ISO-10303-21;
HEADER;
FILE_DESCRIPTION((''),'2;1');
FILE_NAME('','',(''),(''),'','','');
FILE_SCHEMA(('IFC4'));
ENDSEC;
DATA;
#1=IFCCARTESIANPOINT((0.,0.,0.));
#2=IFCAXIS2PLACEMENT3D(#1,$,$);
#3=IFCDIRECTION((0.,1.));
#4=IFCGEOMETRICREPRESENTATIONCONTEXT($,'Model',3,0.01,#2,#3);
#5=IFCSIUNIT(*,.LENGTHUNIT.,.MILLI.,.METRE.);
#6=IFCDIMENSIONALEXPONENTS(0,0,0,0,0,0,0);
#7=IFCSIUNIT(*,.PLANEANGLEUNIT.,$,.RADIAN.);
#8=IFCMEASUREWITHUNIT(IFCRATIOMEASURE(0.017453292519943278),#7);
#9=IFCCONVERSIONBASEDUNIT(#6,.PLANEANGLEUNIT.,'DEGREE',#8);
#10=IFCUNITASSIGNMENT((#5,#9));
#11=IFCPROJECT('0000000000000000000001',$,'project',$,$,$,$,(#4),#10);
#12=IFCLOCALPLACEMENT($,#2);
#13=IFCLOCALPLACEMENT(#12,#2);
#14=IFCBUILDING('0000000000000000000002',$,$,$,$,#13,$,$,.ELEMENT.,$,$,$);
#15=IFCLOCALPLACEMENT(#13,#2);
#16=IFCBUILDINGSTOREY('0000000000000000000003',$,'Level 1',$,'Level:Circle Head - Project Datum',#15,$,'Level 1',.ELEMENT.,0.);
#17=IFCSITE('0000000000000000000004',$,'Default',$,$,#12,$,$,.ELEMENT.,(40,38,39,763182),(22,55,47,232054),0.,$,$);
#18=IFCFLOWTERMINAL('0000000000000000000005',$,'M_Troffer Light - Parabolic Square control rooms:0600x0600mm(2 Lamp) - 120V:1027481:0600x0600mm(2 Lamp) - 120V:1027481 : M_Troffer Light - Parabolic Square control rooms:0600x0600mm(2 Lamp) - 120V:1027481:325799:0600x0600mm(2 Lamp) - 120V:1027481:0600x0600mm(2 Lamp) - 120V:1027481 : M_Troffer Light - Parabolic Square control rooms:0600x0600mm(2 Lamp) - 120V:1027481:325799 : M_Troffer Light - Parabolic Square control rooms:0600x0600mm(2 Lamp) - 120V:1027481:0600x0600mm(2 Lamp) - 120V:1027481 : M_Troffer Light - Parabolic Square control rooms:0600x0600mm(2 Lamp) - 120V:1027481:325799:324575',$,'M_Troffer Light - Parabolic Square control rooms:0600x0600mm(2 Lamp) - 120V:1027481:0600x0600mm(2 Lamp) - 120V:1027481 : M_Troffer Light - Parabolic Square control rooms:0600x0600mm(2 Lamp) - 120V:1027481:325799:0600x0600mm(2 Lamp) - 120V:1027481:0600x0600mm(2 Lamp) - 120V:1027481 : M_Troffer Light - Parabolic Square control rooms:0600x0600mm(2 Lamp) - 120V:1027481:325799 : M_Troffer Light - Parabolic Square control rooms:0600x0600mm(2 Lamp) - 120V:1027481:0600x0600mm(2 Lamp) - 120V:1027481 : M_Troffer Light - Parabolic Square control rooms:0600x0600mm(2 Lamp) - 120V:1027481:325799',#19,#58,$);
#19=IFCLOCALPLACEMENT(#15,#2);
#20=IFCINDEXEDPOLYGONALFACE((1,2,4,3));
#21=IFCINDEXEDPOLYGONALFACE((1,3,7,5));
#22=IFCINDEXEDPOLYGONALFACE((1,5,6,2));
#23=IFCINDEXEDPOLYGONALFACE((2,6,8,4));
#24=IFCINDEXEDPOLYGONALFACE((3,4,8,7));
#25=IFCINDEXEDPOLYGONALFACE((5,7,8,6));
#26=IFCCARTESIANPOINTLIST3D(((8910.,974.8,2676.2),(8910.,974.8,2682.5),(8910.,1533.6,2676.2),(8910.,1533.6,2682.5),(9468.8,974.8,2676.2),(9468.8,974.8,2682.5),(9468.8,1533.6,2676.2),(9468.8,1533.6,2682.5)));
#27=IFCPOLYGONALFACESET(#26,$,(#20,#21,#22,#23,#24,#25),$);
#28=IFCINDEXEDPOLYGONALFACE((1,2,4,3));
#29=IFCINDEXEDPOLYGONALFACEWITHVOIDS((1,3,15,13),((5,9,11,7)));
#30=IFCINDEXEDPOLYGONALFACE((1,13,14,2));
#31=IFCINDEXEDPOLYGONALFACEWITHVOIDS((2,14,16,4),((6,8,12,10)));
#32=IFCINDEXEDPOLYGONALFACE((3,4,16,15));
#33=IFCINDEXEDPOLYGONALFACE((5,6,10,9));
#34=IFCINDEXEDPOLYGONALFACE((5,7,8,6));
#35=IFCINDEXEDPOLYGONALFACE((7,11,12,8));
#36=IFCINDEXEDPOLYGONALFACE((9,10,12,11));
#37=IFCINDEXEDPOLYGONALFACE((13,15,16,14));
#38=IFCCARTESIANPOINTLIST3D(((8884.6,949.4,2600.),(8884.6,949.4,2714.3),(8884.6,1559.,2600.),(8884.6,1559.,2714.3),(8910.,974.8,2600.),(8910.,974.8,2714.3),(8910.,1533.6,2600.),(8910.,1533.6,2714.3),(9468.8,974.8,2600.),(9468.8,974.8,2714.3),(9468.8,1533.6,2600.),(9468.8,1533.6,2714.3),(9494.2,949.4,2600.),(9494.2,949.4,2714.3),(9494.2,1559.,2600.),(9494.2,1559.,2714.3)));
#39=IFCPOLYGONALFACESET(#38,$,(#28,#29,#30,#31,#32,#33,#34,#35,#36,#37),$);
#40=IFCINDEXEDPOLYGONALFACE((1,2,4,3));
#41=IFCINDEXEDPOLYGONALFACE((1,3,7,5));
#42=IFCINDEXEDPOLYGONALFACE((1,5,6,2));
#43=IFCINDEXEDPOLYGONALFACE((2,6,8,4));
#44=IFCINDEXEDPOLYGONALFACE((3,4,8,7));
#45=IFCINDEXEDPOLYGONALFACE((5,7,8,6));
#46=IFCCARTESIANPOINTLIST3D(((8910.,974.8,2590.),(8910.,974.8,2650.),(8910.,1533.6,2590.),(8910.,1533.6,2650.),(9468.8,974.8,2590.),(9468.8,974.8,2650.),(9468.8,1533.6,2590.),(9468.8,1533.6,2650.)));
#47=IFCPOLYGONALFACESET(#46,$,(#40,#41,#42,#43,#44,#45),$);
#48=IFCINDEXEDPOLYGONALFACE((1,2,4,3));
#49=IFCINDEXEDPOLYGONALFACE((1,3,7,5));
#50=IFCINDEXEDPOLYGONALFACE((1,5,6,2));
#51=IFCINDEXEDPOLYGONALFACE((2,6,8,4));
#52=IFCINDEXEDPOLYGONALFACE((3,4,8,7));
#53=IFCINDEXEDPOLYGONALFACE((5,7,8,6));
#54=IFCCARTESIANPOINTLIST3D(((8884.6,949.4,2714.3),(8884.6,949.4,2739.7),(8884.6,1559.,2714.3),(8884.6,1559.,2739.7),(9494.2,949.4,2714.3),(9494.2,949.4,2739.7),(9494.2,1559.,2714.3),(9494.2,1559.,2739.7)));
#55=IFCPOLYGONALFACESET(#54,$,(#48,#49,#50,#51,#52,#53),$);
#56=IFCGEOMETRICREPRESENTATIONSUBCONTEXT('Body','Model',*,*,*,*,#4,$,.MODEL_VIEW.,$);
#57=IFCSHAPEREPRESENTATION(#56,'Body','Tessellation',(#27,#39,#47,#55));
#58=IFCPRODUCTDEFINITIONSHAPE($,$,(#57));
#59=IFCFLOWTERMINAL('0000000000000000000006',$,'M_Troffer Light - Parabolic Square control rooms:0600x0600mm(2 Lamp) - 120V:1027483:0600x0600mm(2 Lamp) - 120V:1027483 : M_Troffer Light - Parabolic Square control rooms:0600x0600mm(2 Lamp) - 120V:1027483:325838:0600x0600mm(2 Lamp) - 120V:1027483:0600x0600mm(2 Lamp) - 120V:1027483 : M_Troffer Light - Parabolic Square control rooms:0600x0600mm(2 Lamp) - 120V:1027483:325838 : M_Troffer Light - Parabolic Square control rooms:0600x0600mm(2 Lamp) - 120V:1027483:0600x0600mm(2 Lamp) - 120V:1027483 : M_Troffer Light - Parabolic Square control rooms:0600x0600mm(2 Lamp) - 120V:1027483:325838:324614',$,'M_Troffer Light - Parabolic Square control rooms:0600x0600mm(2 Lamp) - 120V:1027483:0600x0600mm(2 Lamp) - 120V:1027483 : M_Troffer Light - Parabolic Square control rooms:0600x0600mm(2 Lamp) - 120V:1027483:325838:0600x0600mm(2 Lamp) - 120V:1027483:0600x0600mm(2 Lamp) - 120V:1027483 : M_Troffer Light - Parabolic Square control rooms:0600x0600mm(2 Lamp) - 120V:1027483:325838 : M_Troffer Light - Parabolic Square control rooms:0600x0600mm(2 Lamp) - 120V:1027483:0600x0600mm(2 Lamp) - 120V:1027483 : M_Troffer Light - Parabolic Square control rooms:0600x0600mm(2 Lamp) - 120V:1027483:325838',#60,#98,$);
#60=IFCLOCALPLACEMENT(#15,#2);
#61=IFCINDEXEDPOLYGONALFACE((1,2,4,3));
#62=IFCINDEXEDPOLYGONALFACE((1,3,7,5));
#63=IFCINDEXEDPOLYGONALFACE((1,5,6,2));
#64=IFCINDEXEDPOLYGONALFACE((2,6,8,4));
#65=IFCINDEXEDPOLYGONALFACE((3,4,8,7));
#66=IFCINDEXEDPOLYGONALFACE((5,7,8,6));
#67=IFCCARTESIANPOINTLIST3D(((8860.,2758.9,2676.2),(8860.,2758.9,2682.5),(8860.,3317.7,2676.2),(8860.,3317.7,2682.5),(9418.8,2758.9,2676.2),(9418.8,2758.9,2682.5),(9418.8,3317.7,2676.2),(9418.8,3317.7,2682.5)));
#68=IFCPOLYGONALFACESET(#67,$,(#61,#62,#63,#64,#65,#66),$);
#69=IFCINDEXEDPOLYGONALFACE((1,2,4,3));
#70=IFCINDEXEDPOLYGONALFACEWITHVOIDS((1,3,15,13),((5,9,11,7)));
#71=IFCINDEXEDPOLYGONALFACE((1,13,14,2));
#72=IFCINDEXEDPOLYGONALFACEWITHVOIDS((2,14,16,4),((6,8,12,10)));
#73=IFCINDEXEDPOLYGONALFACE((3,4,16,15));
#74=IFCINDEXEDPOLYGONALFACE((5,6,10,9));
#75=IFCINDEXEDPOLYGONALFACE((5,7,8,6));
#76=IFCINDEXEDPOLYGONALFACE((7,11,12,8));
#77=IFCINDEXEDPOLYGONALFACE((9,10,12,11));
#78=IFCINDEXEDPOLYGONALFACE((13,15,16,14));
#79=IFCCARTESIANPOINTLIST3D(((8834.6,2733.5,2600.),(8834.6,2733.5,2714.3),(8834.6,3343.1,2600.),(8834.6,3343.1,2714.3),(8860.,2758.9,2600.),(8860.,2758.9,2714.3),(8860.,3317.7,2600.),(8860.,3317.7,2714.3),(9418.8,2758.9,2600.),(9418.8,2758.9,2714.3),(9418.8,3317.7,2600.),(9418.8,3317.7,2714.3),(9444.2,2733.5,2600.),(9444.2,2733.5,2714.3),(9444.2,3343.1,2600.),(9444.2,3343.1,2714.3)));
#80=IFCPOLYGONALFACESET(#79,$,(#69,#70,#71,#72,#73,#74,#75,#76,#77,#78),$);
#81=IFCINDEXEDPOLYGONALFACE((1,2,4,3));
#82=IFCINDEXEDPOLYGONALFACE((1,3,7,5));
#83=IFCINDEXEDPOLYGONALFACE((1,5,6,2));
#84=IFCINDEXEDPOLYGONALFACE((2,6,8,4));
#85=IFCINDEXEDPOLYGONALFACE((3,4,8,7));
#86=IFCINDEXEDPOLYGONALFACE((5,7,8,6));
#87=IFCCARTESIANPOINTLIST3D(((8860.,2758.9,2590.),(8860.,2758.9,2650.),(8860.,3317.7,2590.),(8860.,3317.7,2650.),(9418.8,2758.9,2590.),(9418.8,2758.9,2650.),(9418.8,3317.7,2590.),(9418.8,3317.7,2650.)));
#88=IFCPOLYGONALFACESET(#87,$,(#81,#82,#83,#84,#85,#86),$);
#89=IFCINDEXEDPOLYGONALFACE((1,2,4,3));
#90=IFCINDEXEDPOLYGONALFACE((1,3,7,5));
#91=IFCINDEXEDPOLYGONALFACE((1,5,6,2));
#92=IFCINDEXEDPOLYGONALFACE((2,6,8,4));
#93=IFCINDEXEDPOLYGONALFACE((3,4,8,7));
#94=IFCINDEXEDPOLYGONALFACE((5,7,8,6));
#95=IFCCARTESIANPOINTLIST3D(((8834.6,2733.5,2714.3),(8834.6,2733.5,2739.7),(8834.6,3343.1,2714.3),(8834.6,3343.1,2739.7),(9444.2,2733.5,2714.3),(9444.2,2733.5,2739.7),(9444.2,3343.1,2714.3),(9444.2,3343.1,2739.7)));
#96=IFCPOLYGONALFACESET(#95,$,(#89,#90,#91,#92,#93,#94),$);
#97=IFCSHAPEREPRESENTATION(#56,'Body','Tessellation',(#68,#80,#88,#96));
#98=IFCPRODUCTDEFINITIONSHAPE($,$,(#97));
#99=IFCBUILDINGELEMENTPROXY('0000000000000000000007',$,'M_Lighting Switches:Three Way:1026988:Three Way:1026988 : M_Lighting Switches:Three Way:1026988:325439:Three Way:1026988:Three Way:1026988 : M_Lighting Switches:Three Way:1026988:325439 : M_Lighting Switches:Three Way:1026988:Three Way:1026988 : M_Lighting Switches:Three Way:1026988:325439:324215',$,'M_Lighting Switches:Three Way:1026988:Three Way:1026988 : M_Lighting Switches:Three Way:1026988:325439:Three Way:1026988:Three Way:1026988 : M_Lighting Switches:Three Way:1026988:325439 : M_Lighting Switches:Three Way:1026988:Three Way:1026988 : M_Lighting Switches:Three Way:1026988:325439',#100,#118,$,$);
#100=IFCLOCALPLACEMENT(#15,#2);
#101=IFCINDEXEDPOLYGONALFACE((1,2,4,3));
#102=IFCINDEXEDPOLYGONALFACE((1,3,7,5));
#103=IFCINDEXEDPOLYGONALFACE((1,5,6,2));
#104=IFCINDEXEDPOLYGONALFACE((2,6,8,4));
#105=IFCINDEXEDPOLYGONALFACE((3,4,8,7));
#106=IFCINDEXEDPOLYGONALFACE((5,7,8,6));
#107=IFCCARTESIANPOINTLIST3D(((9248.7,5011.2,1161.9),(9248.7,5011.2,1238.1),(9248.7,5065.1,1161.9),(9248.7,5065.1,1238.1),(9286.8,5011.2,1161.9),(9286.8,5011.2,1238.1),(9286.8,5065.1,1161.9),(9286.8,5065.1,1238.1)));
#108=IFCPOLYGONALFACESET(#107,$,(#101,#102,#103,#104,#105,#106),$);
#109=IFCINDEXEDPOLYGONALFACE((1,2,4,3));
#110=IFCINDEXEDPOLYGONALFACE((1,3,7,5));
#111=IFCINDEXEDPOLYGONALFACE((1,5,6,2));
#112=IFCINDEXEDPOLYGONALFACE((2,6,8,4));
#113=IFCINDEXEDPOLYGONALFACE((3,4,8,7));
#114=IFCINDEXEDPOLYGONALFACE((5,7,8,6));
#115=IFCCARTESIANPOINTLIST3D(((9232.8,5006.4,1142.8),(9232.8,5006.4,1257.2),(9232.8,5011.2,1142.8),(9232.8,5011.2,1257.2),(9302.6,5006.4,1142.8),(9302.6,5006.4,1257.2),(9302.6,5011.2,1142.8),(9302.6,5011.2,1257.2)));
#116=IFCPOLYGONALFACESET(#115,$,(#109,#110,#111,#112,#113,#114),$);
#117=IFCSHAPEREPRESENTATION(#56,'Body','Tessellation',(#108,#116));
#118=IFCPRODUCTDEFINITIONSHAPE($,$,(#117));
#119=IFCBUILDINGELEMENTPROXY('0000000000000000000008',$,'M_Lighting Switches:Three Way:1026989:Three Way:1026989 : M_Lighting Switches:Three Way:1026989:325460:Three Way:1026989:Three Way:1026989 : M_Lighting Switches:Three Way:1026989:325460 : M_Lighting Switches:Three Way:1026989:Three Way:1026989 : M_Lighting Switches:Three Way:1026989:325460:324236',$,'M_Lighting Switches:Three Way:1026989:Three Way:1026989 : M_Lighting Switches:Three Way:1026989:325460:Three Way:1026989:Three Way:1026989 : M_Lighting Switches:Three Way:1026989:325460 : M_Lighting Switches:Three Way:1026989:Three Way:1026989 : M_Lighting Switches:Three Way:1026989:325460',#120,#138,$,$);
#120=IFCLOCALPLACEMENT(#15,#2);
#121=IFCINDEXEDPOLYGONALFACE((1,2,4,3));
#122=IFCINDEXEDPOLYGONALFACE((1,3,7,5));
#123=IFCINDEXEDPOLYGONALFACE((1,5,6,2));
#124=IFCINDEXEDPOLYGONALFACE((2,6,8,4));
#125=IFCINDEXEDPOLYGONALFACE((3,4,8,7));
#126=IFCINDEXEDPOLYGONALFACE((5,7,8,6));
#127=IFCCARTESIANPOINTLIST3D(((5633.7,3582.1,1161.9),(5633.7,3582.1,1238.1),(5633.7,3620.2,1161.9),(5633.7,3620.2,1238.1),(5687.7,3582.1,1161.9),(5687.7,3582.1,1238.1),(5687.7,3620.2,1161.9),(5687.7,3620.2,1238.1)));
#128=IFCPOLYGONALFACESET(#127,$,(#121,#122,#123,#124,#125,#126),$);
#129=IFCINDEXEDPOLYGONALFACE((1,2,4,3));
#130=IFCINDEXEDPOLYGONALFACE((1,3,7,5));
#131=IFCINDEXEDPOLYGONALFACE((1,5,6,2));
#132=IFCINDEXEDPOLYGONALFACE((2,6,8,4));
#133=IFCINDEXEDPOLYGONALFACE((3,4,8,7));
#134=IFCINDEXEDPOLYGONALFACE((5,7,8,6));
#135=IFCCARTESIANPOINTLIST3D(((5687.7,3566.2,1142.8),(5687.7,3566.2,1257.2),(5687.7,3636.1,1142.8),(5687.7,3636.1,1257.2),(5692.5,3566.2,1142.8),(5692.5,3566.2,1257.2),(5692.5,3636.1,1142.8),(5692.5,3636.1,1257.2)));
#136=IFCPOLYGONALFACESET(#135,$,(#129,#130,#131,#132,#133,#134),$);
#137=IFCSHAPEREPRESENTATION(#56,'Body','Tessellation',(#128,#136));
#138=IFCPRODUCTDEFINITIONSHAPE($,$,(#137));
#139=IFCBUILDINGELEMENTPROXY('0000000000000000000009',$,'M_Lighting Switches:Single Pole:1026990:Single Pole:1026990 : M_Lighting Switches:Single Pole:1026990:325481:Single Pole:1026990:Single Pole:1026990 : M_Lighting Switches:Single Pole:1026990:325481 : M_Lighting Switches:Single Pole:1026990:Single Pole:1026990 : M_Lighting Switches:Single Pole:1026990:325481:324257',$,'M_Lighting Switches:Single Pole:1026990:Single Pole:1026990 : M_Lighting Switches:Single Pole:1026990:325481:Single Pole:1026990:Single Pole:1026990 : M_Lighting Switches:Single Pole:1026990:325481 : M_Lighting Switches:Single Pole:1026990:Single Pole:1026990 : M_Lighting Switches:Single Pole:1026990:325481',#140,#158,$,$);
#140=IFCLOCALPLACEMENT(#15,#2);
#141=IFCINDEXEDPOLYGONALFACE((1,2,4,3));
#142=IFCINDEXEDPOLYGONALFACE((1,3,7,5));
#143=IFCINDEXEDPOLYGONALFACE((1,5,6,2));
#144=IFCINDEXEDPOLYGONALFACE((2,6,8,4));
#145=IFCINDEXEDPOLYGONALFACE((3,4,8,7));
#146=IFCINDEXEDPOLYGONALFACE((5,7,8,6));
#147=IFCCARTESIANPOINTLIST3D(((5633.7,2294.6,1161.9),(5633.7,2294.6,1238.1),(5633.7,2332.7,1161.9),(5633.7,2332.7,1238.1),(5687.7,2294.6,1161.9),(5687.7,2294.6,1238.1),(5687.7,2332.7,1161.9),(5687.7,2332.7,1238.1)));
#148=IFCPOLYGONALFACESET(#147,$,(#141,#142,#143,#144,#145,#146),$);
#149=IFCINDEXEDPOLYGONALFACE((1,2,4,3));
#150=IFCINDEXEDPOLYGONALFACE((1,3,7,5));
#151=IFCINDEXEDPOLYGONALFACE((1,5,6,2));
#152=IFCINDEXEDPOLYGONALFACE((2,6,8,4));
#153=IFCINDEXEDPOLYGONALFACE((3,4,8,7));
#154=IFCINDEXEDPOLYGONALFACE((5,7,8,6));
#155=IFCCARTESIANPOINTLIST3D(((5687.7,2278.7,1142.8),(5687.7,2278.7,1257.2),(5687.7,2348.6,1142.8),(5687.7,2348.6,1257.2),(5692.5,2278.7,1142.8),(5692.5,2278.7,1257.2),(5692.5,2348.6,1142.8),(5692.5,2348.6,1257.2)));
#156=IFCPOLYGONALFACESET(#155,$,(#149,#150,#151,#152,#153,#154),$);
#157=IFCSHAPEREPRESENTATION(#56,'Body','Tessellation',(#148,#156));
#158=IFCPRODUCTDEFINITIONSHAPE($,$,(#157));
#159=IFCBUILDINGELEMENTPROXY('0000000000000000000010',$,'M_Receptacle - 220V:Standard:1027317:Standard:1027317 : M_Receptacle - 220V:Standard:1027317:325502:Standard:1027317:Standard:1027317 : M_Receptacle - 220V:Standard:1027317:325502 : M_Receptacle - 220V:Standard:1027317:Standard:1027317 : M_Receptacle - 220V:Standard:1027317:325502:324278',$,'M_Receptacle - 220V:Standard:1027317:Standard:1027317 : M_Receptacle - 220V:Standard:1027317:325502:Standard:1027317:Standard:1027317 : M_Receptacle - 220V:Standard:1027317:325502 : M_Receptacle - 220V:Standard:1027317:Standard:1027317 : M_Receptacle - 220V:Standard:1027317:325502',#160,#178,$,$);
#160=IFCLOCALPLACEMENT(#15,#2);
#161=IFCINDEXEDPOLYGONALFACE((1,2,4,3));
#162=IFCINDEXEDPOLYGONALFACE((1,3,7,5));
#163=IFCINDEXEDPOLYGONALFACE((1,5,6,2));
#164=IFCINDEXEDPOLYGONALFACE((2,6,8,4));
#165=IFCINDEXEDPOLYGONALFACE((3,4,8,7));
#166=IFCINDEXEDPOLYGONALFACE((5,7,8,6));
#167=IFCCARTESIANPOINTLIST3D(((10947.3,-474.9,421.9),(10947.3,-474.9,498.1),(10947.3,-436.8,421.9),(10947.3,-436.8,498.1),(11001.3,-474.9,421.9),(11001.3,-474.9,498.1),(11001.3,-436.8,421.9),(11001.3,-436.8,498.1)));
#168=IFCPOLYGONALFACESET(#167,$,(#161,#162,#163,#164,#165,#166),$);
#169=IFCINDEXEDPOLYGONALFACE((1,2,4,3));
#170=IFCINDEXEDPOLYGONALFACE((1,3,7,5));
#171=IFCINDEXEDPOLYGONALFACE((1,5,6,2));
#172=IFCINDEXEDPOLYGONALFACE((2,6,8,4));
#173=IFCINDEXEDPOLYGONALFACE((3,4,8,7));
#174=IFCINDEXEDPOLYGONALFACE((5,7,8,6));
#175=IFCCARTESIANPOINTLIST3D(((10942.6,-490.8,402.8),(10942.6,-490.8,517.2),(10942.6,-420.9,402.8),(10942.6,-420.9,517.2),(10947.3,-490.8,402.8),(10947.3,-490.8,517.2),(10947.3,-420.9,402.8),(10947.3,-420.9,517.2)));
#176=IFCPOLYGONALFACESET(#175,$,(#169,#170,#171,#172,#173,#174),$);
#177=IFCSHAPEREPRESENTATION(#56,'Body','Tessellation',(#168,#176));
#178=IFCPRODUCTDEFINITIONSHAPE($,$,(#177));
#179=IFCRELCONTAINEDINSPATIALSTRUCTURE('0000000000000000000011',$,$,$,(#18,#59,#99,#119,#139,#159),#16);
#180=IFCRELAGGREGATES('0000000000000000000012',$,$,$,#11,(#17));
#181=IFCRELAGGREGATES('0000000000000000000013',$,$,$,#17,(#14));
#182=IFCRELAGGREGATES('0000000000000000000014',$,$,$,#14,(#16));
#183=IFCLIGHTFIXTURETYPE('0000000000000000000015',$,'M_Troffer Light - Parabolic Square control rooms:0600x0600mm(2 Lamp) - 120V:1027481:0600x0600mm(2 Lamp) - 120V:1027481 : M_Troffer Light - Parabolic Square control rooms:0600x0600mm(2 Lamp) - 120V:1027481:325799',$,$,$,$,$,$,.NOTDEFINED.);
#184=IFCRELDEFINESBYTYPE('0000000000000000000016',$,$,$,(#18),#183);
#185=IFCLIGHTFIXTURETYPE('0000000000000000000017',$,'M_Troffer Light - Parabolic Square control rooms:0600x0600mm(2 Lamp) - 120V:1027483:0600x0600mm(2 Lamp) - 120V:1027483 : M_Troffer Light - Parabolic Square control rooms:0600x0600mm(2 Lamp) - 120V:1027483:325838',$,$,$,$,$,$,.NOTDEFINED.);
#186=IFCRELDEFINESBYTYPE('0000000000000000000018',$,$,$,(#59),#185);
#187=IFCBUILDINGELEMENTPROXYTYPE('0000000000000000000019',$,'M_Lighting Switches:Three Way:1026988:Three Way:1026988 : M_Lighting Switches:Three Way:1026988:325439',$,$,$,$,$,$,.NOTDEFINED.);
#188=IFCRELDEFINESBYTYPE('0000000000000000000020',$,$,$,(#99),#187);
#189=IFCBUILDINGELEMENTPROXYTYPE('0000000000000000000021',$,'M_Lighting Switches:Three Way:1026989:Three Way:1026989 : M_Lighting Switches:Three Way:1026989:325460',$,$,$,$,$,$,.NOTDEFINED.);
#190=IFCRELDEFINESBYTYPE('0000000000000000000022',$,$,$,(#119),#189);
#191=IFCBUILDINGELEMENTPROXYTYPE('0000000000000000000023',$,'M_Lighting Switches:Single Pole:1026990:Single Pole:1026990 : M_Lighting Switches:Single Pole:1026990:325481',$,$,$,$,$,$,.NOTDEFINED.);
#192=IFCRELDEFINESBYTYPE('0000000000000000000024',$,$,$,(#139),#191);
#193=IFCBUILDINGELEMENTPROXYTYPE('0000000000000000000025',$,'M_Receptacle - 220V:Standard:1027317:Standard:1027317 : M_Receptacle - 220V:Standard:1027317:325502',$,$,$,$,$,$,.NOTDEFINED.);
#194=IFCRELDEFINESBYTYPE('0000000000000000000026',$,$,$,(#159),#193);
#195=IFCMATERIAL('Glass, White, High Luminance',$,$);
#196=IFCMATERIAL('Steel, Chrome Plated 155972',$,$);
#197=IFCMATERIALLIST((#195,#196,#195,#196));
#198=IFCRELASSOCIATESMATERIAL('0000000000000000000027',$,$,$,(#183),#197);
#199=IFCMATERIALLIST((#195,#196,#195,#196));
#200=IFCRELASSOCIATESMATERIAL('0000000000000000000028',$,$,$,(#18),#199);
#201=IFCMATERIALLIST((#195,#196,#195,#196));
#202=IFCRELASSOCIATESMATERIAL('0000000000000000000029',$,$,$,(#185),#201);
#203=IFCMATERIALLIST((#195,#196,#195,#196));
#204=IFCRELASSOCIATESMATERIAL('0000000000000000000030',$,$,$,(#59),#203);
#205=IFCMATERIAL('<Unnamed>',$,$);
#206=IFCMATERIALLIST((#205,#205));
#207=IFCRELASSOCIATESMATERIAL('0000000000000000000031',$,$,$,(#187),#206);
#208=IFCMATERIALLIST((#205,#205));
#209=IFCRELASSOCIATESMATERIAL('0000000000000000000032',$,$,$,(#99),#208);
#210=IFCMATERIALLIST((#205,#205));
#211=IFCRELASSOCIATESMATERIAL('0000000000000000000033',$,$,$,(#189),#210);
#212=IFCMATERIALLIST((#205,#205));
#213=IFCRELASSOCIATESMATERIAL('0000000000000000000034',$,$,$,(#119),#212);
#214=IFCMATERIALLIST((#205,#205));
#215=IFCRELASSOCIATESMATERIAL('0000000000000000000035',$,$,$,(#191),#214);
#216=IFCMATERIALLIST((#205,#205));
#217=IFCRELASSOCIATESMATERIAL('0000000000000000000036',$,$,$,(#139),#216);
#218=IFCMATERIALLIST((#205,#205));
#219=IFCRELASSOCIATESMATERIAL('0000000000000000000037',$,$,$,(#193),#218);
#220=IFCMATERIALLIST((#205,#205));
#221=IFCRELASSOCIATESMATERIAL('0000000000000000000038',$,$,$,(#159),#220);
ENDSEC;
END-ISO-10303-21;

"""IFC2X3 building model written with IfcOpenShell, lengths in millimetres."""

from ifc_helpers import new_model, entity, si_unit, converted_unit, direction, frame, frame_2d, origin, origin_2d_with_axis, place, context, subcontext, project, spatial, polyline, rectangle, outline, extrude, source, transform, mapped, material, material_list, type_object, type_shapes, element, save


model = new_model("IFC2X3")

# Units and contexts
model_context = context("Model", 3, precision=0.01, world=origin(), true_north=direction((0.0, 1.0)))
body_context = subcontext(model_context, "Body", "Model", "MODEL_VIEW")
ifc_project = project(units=[si_unit("LENGTHUNIT", "METRE", prefix="MILLI"), converted_unit("PLANEANGLEUNIT", "DEGREE", entity("IfcRatioMeasure", 0.017453292519943278), si_unit("PLANEANGLEUNIT", "RADIAN"), dimensions=[0, 0, 0, 0, 0, 0, 0])], contexts=[model_context])

# Site, building, storey
site_placement = place(None, origin())
site = spatial("IfcSite", under=ifc_project, at=site_placement, Name="Default", CompositionType="ELEMENT", RefLatitude=(40, 38, 39, 763182), RefLongitude=(22, 55, 47, 232054), RefElevation=0.0)
building_placement = place(site_placement, origin())
building = spatial("IfcBuilding", under=site, at=building_placement, CompositionType="ELEMENT")
storey_placement = place(building_placement, origin())
storey = spatial("IfcBuildingStorey", under=building, at=storey_placement, Name="Level 1", ObjectType="Level:Circle Head - Project Datum", LongName="Level 1", CompositionType="ELEMENT", Elevation=0.0)

# Flow terminals
ifc_material_1 = material(Name="Glass, White, High Luminance")
ifc_material_2 = material(Name="Steel, Chrome Plated 155972")
ifc_material_list_1 = material_list([ifc_material_1, ifc_material_2, ifc_material_1, ifc_material_2])
ifc_material_list_2 = material_list([ifc_material_1, ifc_material_2, ifc_material_1, ifc_material_2])
light_fixture_type_1 = type_object("IfcLightFixtureType", Name="M_Troffer Light - Parabolic Square control rooms:0600x0600mm(2 Lamp) - 120V:1027481:0600x0600mm(2 Lamp) - 120V:1027481 : M_Troffer Light - Parabolic Square control rooms:0600x0600mm(2 Lamp) - 120V:1027481:325799", PredefinedType="NOTDEFINED", material=ifc_material_list_2)
shared_shape_1 = source(origin(), body_context, "Body", "SweptSolid", [
    extrude(rectangle(XDim=558.8, YDim=558.8, at=origin_2d_with_axis()), frame((9189.4, 1254.2, 2676.2), z_axis=(0.0, 0.0, 1.0), x_axis=(0.0, 1.0, 0.0)), (0.0, 0.0, 1.0), 6.4),
    extrude(outline(polyline([(-304.8, -304.8), (304.8, -304.8), (304.8, 304.8), (-304.8, 304.8), (-304.8, -304.8)]), holes=[polyline([(279.4, 279.4), (279.4, -279.4), (-279.4, -279.4), (-279.4, 279.4), (279.4, 279.4)])]), frame((9189.4, 1254.2, 2600.0), z_axis=(0.0, 0.0, 1.0), x_axis=(0.0, -1.0, 0.0)), (0.0, 0.0, 1.0), 114.3),
    extrude(rectangle(XDim=558.8, YDim=558.8, at=frame_2d((0.0, 0.0), x_axis=(1.0, 0.0))), frame((9189.4, 1254.2, 2590.0), z_axis=(0.0, 0.0, 1.0), x_axis=(0.0, 1.0, 0.0)), (0.0, 0.0, 1.0), 60.0),
    extrude(rectangle(XDim=609.6, YDim=609.6, at=frame_2d((0.0, 0.0), x_axis=(1.0, 0.0))), frame((9189.4, 1254.2, 2714.3), z_axis=(0.0, 0.0, 1.0), x_axis=(0.0, 1.0, 0.0)), (0.0, 0.0, 1.0), 25.4),
])
type_shapes(light_fixture_type_1, [shared_shape_1])
flow_terminal_1_placement = place(storey_placement, origin())
element("IfcFlowTerminal", 1, at=flow_terminal_1_placement, inside=storey, type_object=light_fixture_type_1, material=ifc_material_list_1, Name="M_Troffer Light - Parabolic Square control rooms:0600x0600mm(2 Lamp) - 120V:1027481:0600x0600mm(2 Lamp) - 120V:1027481 : M_Troffer Light - Parabolic Square control rooms:0600x0600mm(2 Lamp) - 120V:1027481:325799:0600x0600mm(2 Lamp) - 120V:1027481:0600x0600mm(2 Lamp) - 120V:1027481 : M_Troffer Light - Parabolic Square control rooms:0600x0600mm(2 Lamp) - 120V:1027481:325799 : M_Troffer Light - Parabolic Square control rooms:0600x0600mm(2 Lamp) - 120V:1027481:0600x0600mm(2 Lamp) - 120V:1027481 : M_Troffer Light - Parabolic Square control rooms:0600x0600mm(2 Lamp) - 120V:1027481:325799:324575", ObjectType="M_Troffer Light - Parabolic Square control rooms:0600x0600mm(2 Lamp) - 120V:1027481:0600x0600mm(2 Lamp) - 120V:1027481 : M_Troffer Light - Parabolic Square control rooms:0600x0600mm(2 Lamp) - 120V:1027481:325799:0600x0600mm(2 Lamp) - 120V:1027481:0600x0600mm(2 Lamp) - 120V:1027481 : M_Troffer Light - Parabolic Square control rooms:0600x0600mm(2 Lamp) - 120V:1027481:325799 : M_Troffer Light - Parabolic Square control rooms:0600x0600mm(2 Lamp) - 120V:1027481:0600x0600mm(2 Lamp) - 120V:1027481 : M_Troffer Light - Parabolic Square control rooms:0600x0600mm(2 Lamp) - 120V:1027481:325799", context=body_context, shape_type="MappedRepresentation", body=[
    mapped(shared_shape_1, transform((0.0, 0.0, 0.0), scale=1.0)),
])
ifc_material_list_3 = material_list([ifc_material_1, ifc_material_2, ifc_material_1, ifc_material_2])
ifc_material_list_4 = material_list([ifc_material_1, ifc_material_2, ifc_material_1, ifc_material_2])
light_fixture_type_2 = type_object("IfcLightFixtureType", Name="M_Troffer Light - Parabolic Square control rooms:0600x0600mm(2 Lamp) - 120V:1027483:0600x0600mm(2 Lamp) - 120V:1027483 : M_Troffer Light - Parabolic Square control rooms:0600x0600mm(2 Lamp) - 120V:1027483:325838", PredefinedType="NOTDEFINED", material=ifc_material_list_4)
shared_shape_2 = source(origin(), body_context, "Body", "SweptSolid", [
    extrude(rectangle(XDim=558.8, YDim=558.8, at=frame_2d((0.0, 0.0), x_axis=(1.0, 0.0))), frame((9139.4, 3038.3, 2676.2), z_axis=(0.0, 0.0, 1.0), x_axis=(0.0, 1.0, 0.0)), (0.0, 0.0, 1.0), 6.4),
    extrude(outline(polyline([(-304.8, -304.8), (304.8, -304.8), (304.8, 304.8), (-304.8, 304.8), (-304.8, -304.8)]), holes=[polyline([(279.4, 279.4), (279.4, -279.4), (-279.4, -279.4), (-279.4, 279.4), (279.4, 279.4)])]), frame((9139.4, 3038.3, 2600.0), z_axis=(0.0, 0.0, 1.0), x_axis=(0.0, -1.0, 0.0)), (0.0, 0.0, 1.0), 114.3),
    extrude(rectangle(XDim=558.8, YDim=558.8, at=frame_2d((0.0, 0.0), x_axis=(1.0, 0.0))), frame((9139.4, 3038.3, 2590.0), z_axis=(0.0, 0.0, 1.0), x_axis=(0.0, 1.0, 0.0)), (0.0, 0.0, 1.0), 60.0),
    extrude(rectangle(XDim=609.6, YDim=609.6, at=frame_2d((0.0, 0.0), x_axis=(1.0, 0.0))), frame((9139.4, 3038.3, 2714.3), z_axis=(0.0, 0.0, 1.0), x_axis=(0.0, 1.0, 0.0)), (0.0, 0.0, 1.0), 25.4),
])
type_shapes(light_fixture_type_2, [shared_shape_2])
flow_terminal_2_placement = place(storey_placement, origin())
element("IfcFlowTerminal", 2, at=flow_terminal_2_placement, inside=storey, type_object=light_fixture_type_2, material=ifc_material_list_3, Name="M_Troffer Light - Parabolic Square control rooms:0600x0600mm(2 Lamp) - 120V:1027483:0600x0600mm(2 Lamp) - 120V:1027483 : M_Troffer Light - Parabolic Square control rooms:0600x0600mm(2 Lamp) - 120V:1027483:325838:0600x0600mm(2 Lamp) - 120V:1027483:0600x0600mm(2 Lamp) - 120V:1027483 : M_Troffer Light - Parabolic Square control rooms:0600x0600mm(2 Lamp) - 120V:1027483:325838 : M_Troffer Light - Parabolic Square control rooms:0600x0600mm(2 Lamp) - 120V:1027483:0600x0600mm(2 Lamp) - 120V:1027483 : M_Troffer Light - Parabolic Square control rooms:0600x0600mm(2 Lamp) - 120V:1027483:325838:324614", ObjectType="M_Troffer Light - Parabolic Square control rooms:0600x0600mm(2 Lamp) - 120V:1027483:0600x0600mm(2 Lamp) - 120V:1027483 : M_Troffer Light - Parabolic Square control rooms:0600x0600mm(2 Lamp) - 120V:1027483:325838:0600x0600mm(2 Lamp) - 120V:1027483:0600x0600mm(2 Lamp) - 120V:1027483 : M_Troffer Light - Parabolic Square control rooms:0600x0600mm(2 Lamp) - 120V:1027483:325838 : M_Troffer Light - Parabolic Square control rooms:0600x0600mm(2 Lamp) - 120V:1027483:0600x0600mm(2 Lamp) - 120V:1027483 : M_Troffer Light - Parabolic Square control rooms:0600x0600mm(2 Lamp) - 120V:1027483:325838", context=body_context, shape_type="MappedRepresentation", body=[
    mapped(shared_shape_2, transform((0.0, 0.0, 0.0), scale=1.0)),
])

# Building element proxies
ifc_material_3 = material(Name="<Unnamed>")
ifc_material_list_5 = material_list([ifc_material_3, ifc_material_3])
ifc_material_list_6 = material_list([ifc_material_3, ifc_material_3])
building_element_proxy_type_1 = type_object("IfcBuildingElementProxyType", Name="M_Lighting Switches:Three Way:1026988:Three Way:1026988 : M_Lighting Switches:Three Way:1026988:325439", PredefinedType="NOTDEFINED", material=ifc_material_list_6)
shared_shape_3 = source(origin(), body_context, "Body", "SweptSolid", [
    extrude(rectangle(XDim=38.1, YDim=54.0, at=origin_2d_with_axis()), frame((9267.7, 5038.1, 1161.9), z_axis=(0.0, 0.0, 1.0), x_axis=(-1.0, 0.0, 0.0)), (0.0, 0.0, 1.0), 76.2),
    extrude(rectangle(XDim=69.8, YDim=4.8, at=frame_2d((0.0, 0.0), x_axis=(1.0, 0.0))), frame((9267.7, 5008.8, 1142.8), z_axis=(0.0, 0.0, 1.0), x_axis=(-1.0, 0.0, 0.0)), (0.0, 0.0, 1.0), 114.3),
])
type_shapes(building_element_proxy_type_1, [shared_shape_3])
proxy_1_placement = place(storey_placement, origin())
element("IfcBuildingElementProxy", 3, at=proxy_1_placement, inside=storey, type_object=building_element_proxy_type_1, material=ifc_material_list_5, Name="M_Lighting Switches:Three Way:1026988:Three Way:1026988 : M_Lighting Switches:Three Way:1026988:325439:Three Way:1026988:Three Way:1026988 : M_Lighting Switches:Three Way:1026988:325439 : M_Lighting Switches:Three Way:1026988:Three Way:1026988 : M_Lighting Switches:Three Way:1026988:325439:324215", ObjectType="M_Lighting Switches:Three Way:1026988:Three Way:1026988 : M_Lighting Switches:Three Way:1026988:325439:Three Way:1026988:Three Way:1026988 : M_Lighting Switches:Three Way:1026988:325439 : M_Lighting Switches:Three Way:1026988:Three Way:1026988 : M_Lighting Switches:Three Way:1026988:325439", context=body_context, shape_type="MappedRepresentation", body=[
    mapped(shared_shape_3, transform((0.0, 0.0, 0.0), scale=1.0)),
])
ifc_material_list_7 = material_list([ifc_material_3, ifc_material_3])
ifc_material_list_8 = material_list([ifc_material_3, ifc_material_3])
building_element_proxy_type_2 = type_object("IfcBuildingElementProxyType", Name="M_Lighting Switches:Three Way:1026989:Three Way:1026989 : M_Lighting Switches:Three Way:1026989:325460", PredefinedType="NOTDEFINED", material=ifc_material_list_8)
shared_shape_4 = source(origin(), body_context, "Body", "SweptSolid", [
    extrude(rectangle(XDim=38.1, YDim=54.0, at=frame_2d((0.0, 0.0), x_axis=(1.0, 0.0))), frame((5660.7, 3601.1, 1161.9), z_axis=(0.0, 0.0, 1.0), x_axis=(0.0, -1.0, 0.0)), (0.0, 0.0, 1.0), 76.2),
    extrude(rectangle(XDim=69.8, YDim=4.8, at=origin_2d_with_axis()), frame((5690.1, 3601.1, 1142.8), z_axis=(0.0, 0.0, 1.0), x_axis=(0.0, -1.0, 0.0)), (0.0, 0.0, 1.0), 114.3),
])
type_shapes(building_element_proxy_type_2, [shared_shape_4])
proxy_2_placement = place(storey_placement, origin())
element("IfcBuildingElementProxy", 4, at=proxy_2_placement, inside=storey, type_object=building_element_proxy_type_2, material=ifc_material_list_7, Name="M_Lighting Switches:Three Way:1026989:Three Way:1026989 : M_Lighting Switches:Three Way:1026989:325460:Three Way:1026989:Three Way:1026989 : M_Lighting Switches:Three Way:1026989:325460 : M_Lighting Switches:Three Way:1026989:Three Way:1026989 : M_Lighting Switches:Three Way:1026989:325460:324236", ObjectType="M_Lighting Switches:Three Way:1026989:Three Way:1026989 : M_Lighting Switches:Three Way:1026989:325460:Three Way:1026989:Three Way:1026989 : M_Lighting Switches:Three Way:1026989:325460 : M_Lighting Switches:Three Way:1026989:Three Way:1026989 : M_Lighting Switches:Three Way:1026989:325460", context=body_context, shape_type="MappedRepresentation", body=[
    mapped(shared_shape_4, transform((0.0, 0.0, 0.0), scale=1.0)),
])
ifc_material_list_9 = material_list([ifc_material_3, ifc_material_3])
ifc_material_list_10 = material_list([ifc_material_3, ifc_material_3])
building_element_proxy_type_3 = type_object("IfcBuildingElementProxyType", Name="M_Lighting Switches:Single Pole:1026990:Single Pole:1026990 : M_Lighting Switches:Single Pole:1026990:325481", PredefinedType="NOTDEFINED", material=ifc_material_list_10)
shared_shape_5 = source(origin(), body_context, "Body", "SweptSolid", [
    extrude(rectangle(XDim=38.1, YDim=54.0, at=origin_2d_with_axis()), frame((5660.7, 2313.7, 1161.9), z_axis=(0.0, 0.0, 1.0), x_axis=(0.0, -1.0, 0.0)), (0.0, 0.0, 1.0), 76.2),
    extrude(rectangle(XDim=69.8, YDim=4.8, at=frame_2d((0.0, 0.0), x_axis=(1.0, 0.0))), frame((5690.1, 2313.7, 1142.8), z_axis=(0.0, 0.0, 1.0), x_axis=(0.0, -1.0, 0.0)), (0.0, 0.0, 1.0), 114.3),
])
type_shapes(building_element_proxy_type_3, [shared_shape_5])
proxy_3_placement = place(storey_placement, origin())
element("IfcBuildingElementProxy", 5, at=proxy_3_placement, inside=storey, type_object=building_element_proxy_type_3, material=ifc_material_list_9, Name="M_Lighting Switches:Single Pole:1026990:Single Pole:1026990 : M_Lighting Switches:Single Pole:1026990:325481:Single Pole:1026990:Single Pole:1026990 : M_Lighting Switches:Single Pole:1026990:325481 : M_Lighting Switches:Single Pole:1026990:Single Pole:1026990 : M_Lighting Switches:Single Pole:1026990:325481:324257", ObjectType="M_Lighting Switches:Single Pole:1026990:Single Pole:1026990 : M_Lighting Switches:Single Pole:1026990:325481:Single Pole:1026990:Single Pole:1026990 : M_Lighting Switches:Single Pole:1026990:325481 : M_Lighting Switches:Single Pole:1026990:Single Pole:1026990 : M_Lighting Switches:Single Pole:1026990:325481", context=body_context, shape_type="MappedRepresentation", body=[
    mapped(shared_shape_5, transform((0.0, 0.0, 0.0), scale=1.0)),
])
ifc_material_list_11 = material_list([ifc_material_3, ifc_material_3])
ifc_material_list_12 = material_list([ifc_material_3, ifc_material_3])
building_element_proxy_type_4 = type_object("IfcBuildingElementProxyType", Name="M_Receptacle - 220V:Standard:1027317:Standard:1027317 : M_Receptacle - 220V:Standard:1027317:325502", PredefinedType="NOTDEFINED", material=ifc_material_list_12)
shared_shape_6 = source(origin(), body_context, "Body", "SweptSolid", [
    extrude(rectangle(XDim=38.1, YDim=54.0, at=frame_2d((0.0, 0.0), x_axis=(1.0, 0.0))), frame((10974.3, -455.8, 421.9), z_axis=(0.0, 0.0, 1.0), x_axis=(0.0, 1.0, 0.0)), (0.0, 0.0, 1.0), 76.2),
    extrude(rectangle(XDim=69.8, YDim=4.8, at=frame_2d((0.0, 0.0), x_axis=(1.0, 0.0))), frame((10945.0, -455.8, 402.8), z_axis=(0.0, 0.0, 1.0), x_axis=(0.0, 1.0, 0.0)), (0.0, 0.0, 1.0), 114.3),
])
type_shapes(building_element_proxy_type_4, [shared_shape_6])
proxy_4_placement = place(storey_placement, origin())
element("IfcBuildingElementProxy", 6, at=proxy_4_placement, inside=storey, type_object=building_element_proxy_type_4, material=ifc_material_list_11, Name="M_Receptacle - 220V:Standard:1027317:Standard:1027317 : M_Receptacle - 220V:Standard:1027317:325502:Standard:1027317:Standard:1027317 : M_Receptacle - 220V:Standard:1027317:325502 : M_Receptacle - 220V:Standard:1027317:Standard:1027317 : M_Receptacle - 220V:Standard:1027317:325502:324278", ObjectType="M_Receptacle - 220V:Standard:1027317:Standard:1027317 : M_Receptacle - 220V:Standard:1027317:325502:Standard:1027317:Standard:1027317 : M_Receptacle - 220V:Standard:1027317:325502 : M_Receptacle - 220V:Standard:1027317:Standard:1027317 : M_Receptacle - 220V:Standard:1027317:325502", context=body_context, shape_type="MappedRepresentation", body=[
    mapped(shared_shape_6, transform((0.0, 0.0, 0.0), scale=1.0)),
])

save(model, "model.ifc")
